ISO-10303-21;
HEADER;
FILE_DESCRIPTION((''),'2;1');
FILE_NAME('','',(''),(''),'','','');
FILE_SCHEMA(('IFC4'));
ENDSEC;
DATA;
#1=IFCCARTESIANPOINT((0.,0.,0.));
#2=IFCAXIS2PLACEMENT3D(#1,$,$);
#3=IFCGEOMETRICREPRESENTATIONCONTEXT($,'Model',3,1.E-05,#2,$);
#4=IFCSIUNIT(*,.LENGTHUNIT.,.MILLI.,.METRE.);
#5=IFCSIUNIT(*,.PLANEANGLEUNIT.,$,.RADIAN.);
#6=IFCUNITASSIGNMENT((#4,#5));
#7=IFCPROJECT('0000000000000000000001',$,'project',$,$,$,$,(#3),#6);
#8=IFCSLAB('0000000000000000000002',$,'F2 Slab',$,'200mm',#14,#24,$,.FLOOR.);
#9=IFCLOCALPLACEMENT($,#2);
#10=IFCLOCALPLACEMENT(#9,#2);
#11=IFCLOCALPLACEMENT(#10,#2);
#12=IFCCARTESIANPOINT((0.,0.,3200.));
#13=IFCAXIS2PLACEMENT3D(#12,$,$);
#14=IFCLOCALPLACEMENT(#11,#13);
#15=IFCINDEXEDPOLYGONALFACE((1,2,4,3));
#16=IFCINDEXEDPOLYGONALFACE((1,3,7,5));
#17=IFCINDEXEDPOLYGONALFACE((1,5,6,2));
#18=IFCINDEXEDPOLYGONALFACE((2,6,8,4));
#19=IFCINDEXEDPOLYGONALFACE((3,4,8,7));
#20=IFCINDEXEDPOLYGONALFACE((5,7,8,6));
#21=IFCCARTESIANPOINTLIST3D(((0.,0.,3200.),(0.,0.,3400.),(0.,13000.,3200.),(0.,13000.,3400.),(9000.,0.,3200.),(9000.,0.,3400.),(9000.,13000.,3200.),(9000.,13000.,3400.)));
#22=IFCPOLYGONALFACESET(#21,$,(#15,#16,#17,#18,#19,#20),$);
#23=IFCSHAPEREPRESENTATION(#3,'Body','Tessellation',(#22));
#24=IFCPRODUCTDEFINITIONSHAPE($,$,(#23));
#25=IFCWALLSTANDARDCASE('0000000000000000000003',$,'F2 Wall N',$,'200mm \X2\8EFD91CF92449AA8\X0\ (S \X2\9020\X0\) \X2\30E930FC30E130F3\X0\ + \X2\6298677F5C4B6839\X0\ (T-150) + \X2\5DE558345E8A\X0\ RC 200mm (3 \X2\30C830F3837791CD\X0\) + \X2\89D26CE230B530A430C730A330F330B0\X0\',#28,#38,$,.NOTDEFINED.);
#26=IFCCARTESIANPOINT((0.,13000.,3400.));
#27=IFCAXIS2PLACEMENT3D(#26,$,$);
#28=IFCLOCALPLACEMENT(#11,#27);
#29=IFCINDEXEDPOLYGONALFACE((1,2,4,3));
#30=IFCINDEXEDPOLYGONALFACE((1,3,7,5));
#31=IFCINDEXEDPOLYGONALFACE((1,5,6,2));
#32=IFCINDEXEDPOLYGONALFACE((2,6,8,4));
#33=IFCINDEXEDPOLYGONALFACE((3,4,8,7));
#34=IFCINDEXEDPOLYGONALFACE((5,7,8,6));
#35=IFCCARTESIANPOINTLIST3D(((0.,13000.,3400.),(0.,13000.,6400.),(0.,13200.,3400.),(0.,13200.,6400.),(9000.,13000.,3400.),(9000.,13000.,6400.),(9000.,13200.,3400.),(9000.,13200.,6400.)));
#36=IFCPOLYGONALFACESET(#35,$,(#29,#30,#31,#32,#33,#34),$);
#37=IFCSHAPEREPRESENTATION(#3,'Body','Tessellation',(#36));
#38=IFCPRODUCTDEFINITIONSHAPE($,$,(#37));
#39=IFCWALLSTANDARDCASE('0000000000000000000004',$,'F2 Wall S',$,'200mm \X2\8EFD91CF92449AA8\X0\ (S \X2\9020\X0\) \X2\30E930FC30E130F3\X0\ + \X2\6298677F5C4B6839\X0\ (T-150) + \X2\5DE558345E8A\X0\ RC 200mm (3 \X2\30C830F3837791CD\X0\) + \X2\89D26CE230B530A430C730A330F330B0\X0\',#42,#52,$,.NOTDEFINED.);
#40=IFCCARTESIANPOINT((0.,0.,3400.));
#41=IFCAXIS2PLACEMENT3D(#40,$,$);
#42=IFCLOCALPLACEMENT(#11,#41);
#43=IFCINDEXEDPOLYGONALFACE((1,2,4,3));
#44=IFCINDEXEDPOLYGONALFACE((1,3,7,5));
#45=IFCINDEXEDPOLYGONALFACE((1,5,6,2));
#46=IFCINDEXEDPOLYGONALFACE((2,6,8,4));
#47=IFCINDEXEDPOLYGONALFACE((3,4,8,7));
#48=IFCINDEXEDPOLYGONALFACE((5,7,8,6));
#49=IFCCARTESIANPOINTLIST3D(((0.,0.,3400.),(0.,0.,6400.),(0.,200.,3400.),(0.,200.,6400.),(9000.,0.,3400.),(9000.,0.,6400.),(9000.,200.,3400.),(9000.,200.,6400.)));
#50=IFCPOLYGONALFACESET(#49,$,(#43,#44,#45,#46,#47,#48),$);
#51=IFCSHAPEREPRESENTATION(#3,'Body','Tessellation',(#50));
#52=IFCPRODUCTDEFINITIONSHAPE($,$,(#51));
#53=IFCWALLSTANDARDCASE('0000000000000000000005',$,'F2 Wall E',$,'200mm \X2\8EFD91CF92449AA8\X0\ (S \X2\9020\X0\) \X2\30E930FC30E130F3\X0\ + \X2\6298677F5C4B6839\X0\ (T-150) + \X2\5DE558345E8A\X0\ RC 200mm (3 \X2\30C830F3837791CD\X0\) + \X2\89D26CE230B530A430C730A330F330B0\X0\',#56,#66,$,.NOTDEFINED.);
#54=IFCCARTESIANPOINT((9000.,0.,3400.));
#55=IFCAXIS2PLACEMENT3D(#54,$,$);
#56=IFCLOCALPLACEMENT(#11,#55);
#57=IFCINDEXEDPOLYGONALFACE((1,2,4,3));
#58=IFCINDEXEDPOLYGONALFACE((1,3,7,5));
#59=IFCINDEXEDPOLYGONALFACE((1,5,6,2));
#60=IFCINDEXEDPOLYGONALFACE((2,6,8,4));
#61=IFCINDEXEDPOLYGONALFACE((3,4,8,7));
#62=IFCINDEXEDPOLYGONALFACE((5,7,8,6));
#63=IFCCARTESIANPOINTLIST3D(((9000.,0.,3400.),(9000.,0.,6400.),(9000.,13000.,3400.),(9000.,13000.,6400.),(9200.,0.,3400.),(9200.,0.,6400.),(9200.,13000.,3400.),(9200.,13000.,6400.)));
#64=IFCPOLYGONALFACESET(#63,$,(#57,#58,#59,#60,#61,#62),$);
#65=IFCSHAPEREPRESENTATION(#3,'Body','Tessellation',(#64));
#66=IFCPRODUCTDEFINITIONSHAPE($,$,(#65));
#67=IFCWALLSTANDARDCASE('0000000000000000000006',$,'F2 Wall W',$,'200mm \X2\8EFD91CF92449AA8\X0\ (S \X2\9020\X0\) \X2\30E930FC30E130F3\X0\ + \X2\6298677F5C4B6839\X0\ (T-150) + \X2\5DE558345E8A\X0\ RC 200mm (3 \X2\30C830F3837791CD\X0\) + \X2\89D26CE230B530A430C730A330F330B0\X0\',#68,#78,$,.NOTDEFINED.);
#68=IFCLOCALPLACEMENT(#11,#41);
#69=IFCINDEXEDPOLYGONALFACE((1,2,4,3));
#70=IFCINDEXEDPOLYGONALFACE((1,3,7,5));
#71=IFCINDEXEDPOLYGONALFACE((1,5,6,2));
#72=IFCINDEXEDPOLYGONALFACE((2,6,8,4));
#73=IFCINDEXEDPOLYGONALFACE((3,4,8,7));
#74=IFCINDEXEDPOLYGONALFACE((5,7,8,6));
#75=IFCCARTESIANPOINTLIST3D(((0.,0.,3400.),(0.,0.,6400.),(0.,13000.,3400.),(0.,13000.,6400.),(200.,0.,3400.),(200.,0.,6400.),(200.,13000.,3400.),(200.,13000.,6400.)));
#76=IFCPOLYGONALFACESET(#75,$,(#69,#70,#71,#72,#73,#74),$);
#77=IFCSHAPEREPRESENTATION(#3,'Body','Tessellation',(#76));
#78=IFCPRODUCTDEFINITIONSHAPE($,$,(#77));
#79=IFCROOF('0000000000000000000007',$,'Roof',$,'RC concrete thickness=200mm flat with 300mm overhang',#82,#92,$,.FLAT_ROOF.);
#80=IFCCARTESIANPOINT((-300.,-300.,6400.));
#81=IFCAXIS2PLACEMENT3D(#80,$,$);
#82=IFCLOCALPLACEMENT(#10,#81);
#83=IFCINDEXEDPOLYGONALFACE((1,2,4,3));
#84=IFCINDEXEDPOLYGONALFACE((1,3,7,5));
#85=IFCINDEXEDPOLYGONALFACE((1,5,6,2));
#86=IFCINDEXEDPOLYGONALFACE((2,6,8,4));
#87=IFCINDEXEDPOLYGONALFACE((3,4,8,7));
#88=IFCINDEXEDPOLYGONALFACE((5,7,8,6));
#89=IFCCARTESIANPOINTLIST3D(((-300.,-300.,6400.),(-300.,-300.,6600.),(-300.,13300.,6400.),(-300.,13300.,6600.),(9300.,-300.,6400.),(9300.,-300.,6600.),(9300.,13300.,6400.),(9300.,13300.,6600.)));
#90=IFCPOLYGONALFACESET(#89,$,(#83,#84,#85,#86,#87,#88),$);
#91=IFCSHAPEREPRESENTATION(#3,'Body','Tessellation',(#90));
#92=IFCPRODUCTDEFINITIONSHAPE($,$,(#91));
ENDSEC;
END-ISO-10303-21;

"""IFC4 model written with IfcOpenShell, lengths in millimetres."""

from ifc_helpers import new_model, si_unit, frame, frame_2d, origin, place, context, project, rectangle, extrude, element, save


model = new_model("IFC4")

# Units and contexts
model_context = context("Model", 3, precision=1e-05, world=origin())
ifc_project = project(units=[si_unit("LENGTHUNIT", "METRE", prefix="MILLI"), si_unit("PLANEANGLEUNIT", "RADIAN")], contexts=[model_context])

# Slab
placement_1 = place(None, origin())
placement_2 = place(placement_1, origin())
placement_3 = place(placement_2, origin())
slab_placement = place(placement_3, frame((0.0, 0.0, 3200.0)))
element("IfcSlab", 1, at=slab_placement, Name="F2 Slab", ObjectType="200mm", PredefinedType="FLOOR", context=model_context, shape_type="SweptSolid", body=[
    extrude(rectangle(XDim=9000.0, YDim=13000.0, at=frame_2d((4500.0, 6500.0))), frame((0.0, 0.0, 3200.0)), (0.0, 0.0, 1.0), 200.0),
])

# Walls
wall_1_placement = place(placement_3, frame((0.0, 13000.0, 3400.0)))
element("IfcWallStandardCase", 2, at=wall_1_placement, Name="F2 Wall N", ObjectType="200mm 軽量鉄骨 (S 造) ラーメン + 折板屋根 (T-150) + 工場床 RC 200mm (3 トン荷重) + 角波サイディング", PredefinedType="NOTDEFINED", context=model_context, shape_type="SweptSolid", body=[
    extrude(rectangle(XDim=9000.0, YDim=200.0, at=frame_2d((4500.0, 100.0))), frame((0.0, 13000.0, 3400.0)), (0.0, 0.0, 1.0), 3000.0),
])
wall_2_placement = place(placement_3, frame((0.0, 0.0, 3400.0)))
element("IfcWallStandardCase", 3, at=wall_2_placement, Name="F2 Wall S", ObjectType="200mm 軽量鉄骨 (S 造) ラーメン + 折板屋根 (T-150) + 工場床 RC 200mm (3 トン荷重) + 角波サイディング", PredefinedType="NOTDEFINED", context=model_context, shape_type="SweptSolid", body=[
    extrude(rectangle(XDim=9000.0, YDim=200.0, at=frame_2d((4500.0, 100.0))), frame((0.0, 0.0, 3400.0)), (0.0, 0.0, 1.0), 3000.0),
])
wall_3_placement = place(placement_3, frame((9000.0, 0.0, 3400.0)))
element("IfcWallStandardCase", 4, at=wall_3_placement, Name="F2 Wall E", ObjectType="200mm 軽量鉄骨 (S 造) ラーメン + 折板屋根 (T-150) + 工場床 RC 200mm (3 トン荷重) + 角波サイディング", PredefinedType="NOTDEFINED", context=model_context, shape_type="SweptSolid", body=[
    extrude(rectangle(XDim=200.0, YDim=13000.0, at=frame_2d((100.0, 6500.0))), frame((9000.0, 0.0, 3400.0)), (0.0, 0.0, 1.0), 3000.0),
])
wall_4_placement = place(placement_3, frame((0.0, 0.0, 3400.0)))
element("IfcWallStandardCase", 5, at=wall_4_placement, Name="F2 Wall W", ObjectType="200mm 軽量鉄骨 (S 造) ラーメン + 折板屋根 (T-150) + 工場床 RC 200mm (3 トン荷重) + 角波サイディング", PredefinedType="NOTDEFINED", context=model_context, shape_type="SweptSolid", body=[
    extrude(rectangle(XDim=200.0, YDim=13000.0, at=frame_2d((100.0, 6500.0))), frame((0.0, 0.0, 3400.0)), (0.0, 0.0, 1.0), 3000.0),
])

# Roof
roof_placement = place(placement_2, frame((-300.0, -300.0, 6400.0)))
element("IfcRoof", 6, at=roof_placement, Name="Roof", ObjectType="RC concrete thickness=200mm flat with 300mm overhang", PredefinedType="FLAT_ROOF", context=model_context, shape_type="SweptSolid", body=[
    extrude(rectangle(XDim=9600.0, YDim=13600.0, at=frame_2d((4800.0, 6800.0))), frame((-300.0, -300.0, 6400.0)), (0.0, 0.0, 1.0), 200.0),
])

save(model, "model.ifc")
